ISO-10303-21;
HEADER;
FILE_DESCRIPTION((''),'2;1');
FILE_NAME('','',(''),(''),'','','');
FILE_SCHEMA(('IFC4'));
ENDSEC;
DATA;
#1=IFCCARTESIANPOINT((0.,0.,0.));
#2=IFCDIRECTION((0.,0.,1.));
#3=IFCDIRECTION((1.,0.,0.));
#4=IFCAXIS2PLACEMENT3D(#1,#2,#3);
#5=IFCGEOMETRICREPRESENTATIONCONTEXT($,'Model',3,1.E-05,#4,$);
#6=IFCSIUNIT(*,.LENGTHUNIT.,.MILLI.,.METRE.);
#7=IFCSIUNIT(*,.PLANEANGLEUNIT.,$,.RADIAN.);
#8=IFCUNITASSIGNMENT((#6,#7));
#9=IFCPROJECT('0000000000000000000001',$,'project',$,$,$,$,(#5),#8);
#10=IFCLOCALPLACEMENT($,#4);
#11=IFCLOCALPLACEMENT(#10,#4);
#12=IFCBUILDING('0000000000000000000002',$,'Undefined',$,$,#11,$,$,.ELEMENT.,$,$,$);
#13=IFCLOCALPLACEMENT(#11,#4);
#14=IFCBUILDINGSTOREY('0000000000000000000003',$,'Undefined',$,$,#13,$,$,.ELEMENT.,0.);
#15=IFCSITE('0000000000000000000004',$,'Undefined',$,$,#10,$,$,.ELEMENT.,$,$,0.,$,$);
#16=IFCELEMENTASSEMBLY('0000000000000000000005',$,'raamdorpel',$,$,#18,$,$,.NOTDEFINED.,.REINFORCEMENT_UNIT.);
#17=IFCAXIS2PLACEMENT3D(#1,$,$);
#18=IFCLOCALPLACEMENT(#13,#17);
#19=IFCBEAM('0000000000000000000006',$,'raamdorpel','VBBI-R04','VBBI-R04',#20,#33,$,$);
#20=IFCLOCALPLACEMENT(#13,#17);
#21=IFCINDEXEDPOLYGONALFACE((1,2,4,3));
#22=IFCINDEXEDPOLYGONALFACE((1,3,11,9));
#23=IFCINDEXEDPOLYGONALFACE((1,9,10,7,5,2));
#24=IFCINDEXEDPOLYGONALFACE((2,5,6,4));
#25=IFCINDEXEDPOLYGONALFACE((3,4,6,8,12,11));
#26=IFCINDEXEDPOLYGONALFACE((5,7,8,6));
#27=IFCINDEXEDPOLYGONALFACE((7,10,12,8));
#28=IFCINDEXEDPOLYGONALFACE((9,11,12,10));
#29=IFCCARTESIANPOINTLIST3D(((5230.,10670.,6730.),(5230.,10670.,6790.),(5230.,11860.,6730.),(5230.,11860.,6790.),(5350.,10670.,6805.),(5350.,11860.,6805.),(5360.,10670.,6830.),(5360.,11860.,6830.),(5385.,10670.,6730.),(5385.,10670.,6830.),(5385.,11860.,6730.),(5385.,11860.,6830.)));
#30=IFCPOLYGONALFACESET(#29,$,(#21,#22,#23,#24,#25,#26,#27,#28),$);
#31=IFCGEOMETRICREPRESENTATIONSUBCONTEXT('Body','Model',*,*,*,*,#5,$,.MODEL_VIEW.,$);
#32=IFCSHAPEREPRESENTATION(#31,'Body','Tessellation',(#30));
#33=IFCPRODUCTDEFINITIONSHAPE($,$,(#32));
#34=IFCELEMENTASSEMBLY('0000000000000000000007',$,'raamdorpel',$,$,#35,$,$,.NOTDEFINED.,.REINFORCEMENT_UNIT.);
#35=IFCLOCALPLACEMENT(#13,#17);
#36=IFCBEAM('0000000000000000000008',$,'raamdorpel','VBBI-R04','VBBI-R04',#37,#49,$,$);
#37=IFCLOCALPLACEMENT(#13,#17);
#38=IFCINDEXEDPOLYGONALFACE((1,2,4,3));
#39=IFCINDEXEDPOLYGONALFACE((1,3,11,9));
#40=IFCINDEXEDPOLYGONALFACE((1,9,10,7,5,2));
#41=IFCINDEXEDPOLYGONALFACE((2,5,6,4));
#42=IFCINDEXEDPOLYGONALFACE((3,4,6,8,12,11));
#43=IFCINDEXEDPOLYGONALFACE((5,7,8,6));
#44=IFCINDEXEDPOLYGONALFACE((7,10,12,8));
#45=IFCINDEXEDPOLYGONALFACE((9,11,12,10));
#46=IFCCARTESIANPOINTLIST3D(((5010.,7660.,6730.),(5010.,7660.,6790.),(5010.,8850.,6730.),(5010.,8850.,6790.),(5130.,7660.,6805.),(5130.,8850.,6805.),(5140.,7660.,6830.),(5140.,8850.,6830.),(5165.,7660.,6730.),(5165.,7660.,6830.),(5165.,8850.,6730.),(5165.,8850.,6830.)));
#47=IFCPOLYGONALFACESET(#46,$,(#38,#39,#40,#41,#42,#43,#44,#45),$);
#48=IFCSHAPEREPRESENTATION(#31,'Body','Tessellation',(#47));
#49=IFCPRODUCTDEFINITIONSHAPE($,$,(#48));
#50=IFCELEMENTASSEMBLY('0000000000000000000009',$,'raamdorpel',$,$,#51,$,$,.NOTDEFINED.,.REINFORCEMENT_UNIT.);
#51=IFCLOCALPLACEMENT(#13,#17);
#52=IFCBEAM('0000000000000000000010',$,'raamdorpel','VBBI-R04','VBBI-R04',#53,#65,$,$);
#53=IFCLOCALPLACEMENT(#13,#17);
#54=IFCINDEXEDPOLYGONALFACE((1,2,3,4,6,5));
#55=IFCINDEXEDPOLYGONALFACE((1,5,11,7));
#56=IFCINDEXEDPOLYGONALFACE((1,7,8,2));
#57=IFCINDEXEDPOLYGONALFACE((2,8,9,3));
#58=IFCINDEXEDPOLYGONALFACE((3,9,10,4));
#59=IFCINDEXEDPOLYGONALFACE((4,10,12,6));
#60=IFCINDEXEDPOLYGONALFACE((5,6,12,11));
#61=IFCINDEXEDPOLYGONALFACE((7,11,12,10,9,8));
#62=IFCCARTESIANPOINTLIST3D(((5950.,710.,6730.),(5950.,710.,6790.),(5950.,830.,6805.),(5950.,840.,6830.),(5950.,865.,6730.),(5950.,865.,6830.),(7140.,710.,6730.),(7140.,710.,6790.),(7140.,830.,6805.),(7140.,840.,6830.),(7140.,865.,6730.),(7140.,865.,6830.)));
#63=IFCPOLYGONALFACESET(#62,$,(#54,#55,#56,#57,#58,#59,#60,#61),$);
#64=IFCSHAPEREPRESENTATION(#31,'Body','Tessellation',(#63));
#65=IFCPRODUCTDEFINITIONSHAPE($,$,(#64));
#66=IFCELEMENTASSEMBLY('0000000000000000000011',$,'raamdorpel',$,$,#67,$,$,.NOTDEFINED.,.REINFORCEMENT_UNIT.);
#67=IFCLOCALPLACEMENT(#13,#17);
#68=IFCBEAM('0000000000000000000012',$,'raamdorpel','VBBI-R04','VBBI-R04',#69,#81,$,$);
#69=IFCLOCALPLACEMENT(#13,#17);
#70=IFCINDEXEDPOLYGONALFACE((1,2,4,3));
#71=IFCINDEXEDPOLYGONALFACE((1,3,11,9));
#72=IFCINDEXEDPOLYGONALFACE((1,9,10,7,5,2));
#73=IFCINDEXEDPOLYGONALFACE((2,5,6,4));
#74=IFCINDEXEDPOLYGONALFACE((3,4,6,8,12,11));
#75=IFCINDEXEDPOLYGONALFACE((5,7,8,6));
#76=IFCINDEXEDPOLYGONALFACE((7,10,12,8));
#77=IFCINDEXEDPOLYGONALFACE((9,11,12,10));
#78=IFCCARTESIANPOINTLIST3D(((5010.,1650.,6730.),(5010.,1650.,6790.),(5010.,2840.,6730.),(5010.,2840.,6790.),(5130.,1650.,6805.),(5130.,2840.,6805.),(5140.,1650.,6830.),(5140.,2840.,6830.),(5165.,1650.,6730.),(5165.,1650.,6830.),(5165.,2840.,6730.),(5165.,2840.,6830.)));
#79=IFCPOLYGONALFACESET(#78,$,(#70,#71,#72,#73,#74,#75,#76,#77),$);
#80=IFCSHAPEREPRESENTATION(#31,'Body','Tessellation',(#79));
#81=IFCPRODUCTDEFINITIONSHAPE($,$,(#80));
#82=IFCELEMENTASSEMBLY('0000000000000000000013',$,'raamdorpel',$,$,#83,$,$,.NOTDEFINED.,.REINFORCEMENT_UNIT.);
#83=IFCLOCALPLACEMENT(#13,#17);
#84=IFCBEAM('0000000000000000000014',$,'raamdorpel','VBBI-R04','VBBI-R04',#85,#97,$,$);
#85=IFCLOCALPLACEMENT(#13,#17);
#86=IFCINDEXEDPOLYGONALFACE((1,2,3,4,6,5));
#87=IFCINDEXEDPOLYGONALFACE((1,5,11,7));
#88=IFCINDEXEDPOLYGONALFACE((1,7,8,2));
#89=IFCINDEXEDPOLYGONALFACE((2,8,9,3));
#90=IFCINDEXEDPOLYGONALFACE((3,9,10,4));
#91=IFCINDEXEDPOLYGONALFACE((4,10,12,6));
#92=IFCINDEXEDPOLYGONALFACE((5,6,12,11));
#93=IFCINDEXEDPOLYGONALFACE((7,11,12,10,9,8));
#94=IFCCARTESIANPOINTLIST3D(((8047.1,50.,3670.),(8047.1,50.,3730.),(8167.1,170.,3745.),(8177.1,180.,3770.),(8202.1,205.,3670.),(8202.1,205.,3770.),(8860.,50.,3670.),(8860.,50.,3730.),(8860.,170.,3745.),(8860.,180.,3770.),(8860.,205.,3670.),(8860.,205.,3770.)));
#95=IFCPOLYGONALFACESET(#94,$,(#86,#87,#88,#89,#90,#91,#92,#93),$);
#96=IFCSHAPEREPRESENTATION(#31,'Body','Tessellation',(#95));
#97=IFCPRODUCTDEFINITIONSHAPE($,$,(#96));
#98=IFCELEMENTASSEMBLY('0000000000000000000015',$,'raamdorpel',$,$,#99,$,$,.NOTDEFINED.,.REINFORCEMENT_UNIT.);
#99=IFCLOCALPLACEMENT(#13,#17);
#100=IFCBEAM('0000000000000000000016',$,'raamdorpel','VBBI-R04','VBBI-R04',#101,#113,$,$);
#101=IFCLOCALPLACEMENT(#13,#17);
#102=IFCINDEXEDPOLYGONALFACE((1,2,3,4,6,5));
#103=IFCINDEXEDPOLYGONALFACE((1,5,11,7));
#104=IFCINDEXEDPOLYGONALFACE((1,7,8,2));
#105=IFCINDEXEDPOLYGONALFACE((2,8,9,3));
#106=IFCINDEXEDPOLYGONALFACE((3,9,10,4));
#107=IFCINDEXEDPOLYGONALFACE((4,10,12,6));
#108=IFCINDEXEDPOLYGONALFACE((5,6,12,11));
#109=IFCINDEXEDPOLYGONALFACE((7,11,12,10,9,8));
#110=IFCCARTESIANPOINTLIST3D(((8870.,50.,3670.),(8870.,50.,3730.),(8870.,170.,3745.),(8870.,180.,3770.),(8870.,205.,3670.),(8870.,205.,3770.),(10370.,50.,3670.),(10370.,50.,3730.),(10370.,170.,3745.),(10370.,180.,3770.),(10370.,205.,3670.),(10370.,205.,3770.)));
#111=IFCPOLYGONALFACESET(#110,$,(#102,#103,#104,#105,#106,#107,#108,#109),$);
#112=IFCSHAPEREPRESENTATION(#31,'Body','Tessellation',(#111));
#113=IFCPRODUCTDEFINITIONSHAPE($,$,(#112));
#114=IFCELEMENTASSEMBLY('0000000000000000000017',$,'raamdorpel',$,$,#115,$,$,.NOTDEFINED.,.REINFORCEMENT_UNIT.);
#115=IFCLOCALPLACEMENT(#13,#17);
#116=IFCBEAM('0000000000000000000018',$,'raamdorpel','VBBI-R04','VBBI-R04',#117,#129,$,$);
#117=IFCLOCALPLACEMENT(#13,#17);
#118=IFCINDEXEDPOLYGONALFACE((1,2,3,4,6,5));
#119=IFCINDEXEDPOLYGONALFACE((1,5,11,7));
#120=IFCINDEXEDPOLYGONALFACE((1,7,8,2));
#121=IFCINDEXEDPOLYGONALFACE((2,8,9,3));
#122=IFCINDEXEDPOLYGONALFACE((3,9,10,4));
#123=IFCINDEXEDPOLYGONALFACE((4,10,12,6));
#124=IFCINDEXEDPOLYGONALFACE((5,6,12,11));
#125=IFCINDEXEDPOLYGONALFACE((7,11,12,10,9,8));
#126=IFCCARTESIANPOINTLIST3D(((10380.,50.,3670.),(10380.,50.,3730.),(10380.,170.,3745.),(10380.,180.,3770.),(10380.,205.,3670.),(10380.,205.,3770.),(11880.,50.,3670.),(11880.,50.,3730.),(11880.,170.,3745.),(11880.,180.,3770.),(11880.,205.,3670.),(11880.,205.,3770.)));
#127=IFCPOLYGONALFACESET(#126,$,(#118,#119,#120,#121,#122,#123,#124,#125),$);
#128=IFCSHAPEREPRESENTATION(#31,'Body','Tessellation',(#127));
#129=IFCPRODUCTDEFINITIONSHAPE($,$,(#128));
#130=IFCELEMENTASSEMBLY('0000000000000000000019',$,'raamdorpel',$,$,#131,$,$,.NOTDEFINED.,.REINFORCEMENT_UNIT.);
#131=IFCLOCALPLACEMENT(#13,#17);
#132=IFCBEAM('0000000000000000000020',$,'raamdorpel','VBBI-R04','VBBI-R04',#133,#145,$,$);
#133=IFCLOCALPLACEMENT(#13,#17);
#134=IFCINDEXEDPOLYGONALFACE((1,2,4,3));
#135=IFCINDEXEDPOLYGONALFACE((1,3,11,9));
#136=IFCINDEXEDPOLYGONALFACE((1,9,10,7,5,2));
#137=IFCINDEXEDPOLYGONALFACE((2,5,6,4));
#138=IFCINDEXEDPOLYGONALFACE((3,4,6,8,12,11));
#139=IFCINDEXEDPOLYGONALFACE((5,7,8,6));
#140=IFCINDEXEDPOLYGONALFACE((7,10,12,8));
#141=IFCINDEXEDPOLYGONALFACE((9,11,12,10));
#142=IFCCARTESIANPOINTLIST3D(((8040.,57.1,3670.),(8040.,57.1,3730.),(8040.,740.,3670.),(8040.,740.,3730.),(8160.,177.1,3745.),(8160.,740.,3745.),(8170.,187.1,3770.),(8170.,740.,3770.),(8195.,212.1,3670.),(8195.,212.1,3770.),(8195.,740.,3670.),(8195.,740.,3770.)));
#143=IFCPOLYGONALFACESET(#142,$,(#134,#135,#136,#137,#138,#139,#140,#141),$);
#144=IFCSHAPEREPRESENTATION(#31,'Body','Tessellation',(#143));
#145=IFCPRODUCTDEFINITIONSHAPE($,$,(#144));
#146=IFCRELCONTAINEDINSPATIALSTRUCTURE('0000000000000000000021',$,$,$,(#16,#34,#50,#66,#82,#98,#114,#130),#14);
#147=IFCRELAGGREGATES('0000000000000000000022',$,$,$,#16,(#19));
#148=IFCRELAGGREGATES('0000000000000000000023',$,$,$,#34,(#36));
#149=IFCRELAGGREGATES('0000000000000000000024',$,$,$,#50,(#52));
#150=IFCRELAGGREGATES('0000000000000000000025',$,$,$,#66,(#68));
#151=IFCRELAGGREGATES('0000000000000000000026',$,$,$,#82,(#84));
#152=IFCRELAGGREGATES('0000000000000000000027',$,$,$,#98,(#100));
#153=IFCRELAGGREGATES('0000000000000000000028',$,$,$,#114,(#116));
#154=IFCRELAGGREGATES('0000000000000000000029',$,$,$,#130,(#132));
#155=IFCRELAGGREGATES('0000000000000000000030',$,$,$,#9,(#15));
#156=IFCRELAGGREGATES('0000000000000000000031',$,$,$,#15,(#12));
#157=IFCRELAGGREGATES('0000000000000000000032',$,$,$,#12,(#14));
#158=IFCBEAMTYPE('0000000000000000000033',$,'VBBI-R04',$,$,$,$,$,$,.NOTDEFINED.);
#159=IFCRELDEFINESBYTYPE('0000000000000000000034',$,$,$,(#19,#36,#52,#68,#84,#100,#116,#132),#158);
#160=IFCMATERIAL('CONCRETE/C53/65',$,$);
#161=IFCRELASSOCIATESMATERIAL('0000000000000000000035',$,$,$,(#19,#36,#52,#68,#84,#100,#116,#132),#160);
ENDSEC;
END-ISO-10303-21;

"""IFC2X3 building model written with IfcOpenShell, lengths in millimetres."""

from ifc_helpers import new_model, si_unit, frame, origin_with_axes, place, context, subcontext, project, spatial, polyline, outline, extrude, clip, halfspace, material, type_object, element, aggregate, save


model = new_model("IFC2X3")

# Units and contexts
model_context = context("Model", 3, precision=1e-05, world=origin_with_axes())
body_context = subcontext(model_context, "Body", "Model", "MODEL_VIEW")
ifc_project = project(units=[si_unit("LENGTHUNIT", "METRE", prefix="MILLI"), si_unit("PLANEANGLEUNIT", "RADIAN")], contexts=[model_context])

# Site, building, storey
site_placement = place(None, origin_with_axes())
site = spatial("IfcSite", under=ifc_project, at=site_placement, Name="Undefined", CompositionType="ELEMENT", RefElevation=0.0)
building_placement = place(site_placement, origin_with_axes())
building = spatial("IfcBuilding", under=site, at=building_placement, Name="Undefined", CompositionType="ELEMENT")
storey_placement = place(building_placement, origin_with_axes())
storey = spatial("IfcBuildingStorey", under=building, at=storey_placement, Name="Undefined", CompositionType="ELEMENT", Elevation=0.0)

# Element assemblies, beams
ifc_material = material(Name="CONCRETE/C53/65")
assembly_1_placement = place(storey_placement, origin_with_axes())
assembly_1 = element("IfcElementAssembly", 1, at=assembly_1_placement, inside=storey, Name="raamdorpel", AssemblyPlace="NOTDEFINED", PredefinedType="REINFORCEMENT_UNIT")
beam_type_1 = type_object("IfcBeamType", Name="VBBI-R04", PredefinedType="NOTDEFINED")
beam_1_placement = place(assembly_1_placement, frame((5307.5, 11860.0, 6780.0), z_axis=(-1.0, 0.0, 0.0), x_axis=(0.0, -1.0, 0.0)))
beam_1 = element("IfcBeam", 2, at=beam_1_placement, type_object=beam_type_1, material=ifc_material, Name="raamdorpel", Description="VBBI-R04", ObjectType="VBBI-R04", context=body_context, shape_type="SweptSolid", body=[
    extrude(outline(polyline([(50.0, -77.5), (-50.0, -77.5), (-50.0, -52.5), (-25.0, -42.5), (-10.0, 77.5), (50.0, 77.5), (50.0, -77.5)])), frame((1190.0, 0.0, 0.0), z_axis=(-1.0, 0.0, 0.0), x_axis=(0.0, -1.0, 0.0)), (0.0, 0.0, 1.0), 1190.0),
])
aggregate(assembly_1, [beam_1])
assembly_2_placement = place(storey_placement, origin_with_axes())
assembly_2 = element("IfcElementAssembly", 3, at=assembly_2_placement, inside=storey, Name="raamdorpel", AssemblyPlace="NOTDEFINED", PredefinedType="REINFORCEMENT_UNIT")
beam_2_placement = place(assembly_2_placement, frame((5087.5, 8850.0, 6780.0), z_axis=(-1.0, 0.0, 0.0), x_axis=(0.0, -1.0, 0.0)))
beam_2 = element("IfcBeam", 4, at=beam_2_placement, type_object=beam_type_1, material=ifc_material, Name="raamdorpel", Description="VBBI-R04", ObjectType="VBBI-R04", context=body_context, shape_type="SweptSolid", body=[
    extrude(outline(polyline([(50.0, -77.5), (-50.0, -77.5), (-50.0, -52.5), (-25.0, -42.5), (-10.0, 77.5), (50.0, 77.5), (50.0, -77.5)])), frame((1190.0, 0.0, 0.0), z_axis=(-1.0, 0.0, 0.0), x_axis=(0.0, -1.0, 0.0)), (0.0, 0.0, 1.0), 1190.0),
])
aggregate(assembly_2, [beam_2])
assembly_3_placement = place(storey_placement, origin_with_axes())
assembly_3 = element("IfcElementAssembly", 5, at=assembly_3_placement, inside=storey, Name="raamdorpel", AssemblyPlace="NOTDEFINED", PredefinedType="REINFORCEMENT_UNIT")
beam_3_placement = place(assembly_3_placement, frame((5950.0, 787.5, 6780.0), z_axis=(0.0, -1.0, 0.0), x_axis=(1.0, 0.0, 0.0)))
beam_3 = element("IfcBeam", 6, at=beam_3_placement, type_object=beam_type_1, material=ifc_material, Name="raamdorpel", Description="VBBI-R04", ObjectType="VBBI-R04", context=body_context, shape_type="SweptSolid", body=[
    extrude(outline(polyline([(50.0, -77.5), (-50.0, -77.5), (-50.0, -52.5), (-25.0, -42.5), (-10.0, 77.5), (50.0, 77.5), (50.0, -77.5)])), frame((1190.0, 0.0, 0.0), z_axis=(-1.0, 0.0, 0.0), x_axis=(0.0, -1.0, 0.0)), (0.0, 0.0, 1.0), 1190.0),
])
aggregate(assembly_3, [beam_3])
assembly_4_placement = place(storey_placement, origin_with_axes())
assembly_4 = element("IfcElementAssembly", 7, at=assembly_4_placement, inside=storey, Name="raamdorpel", AssemblyPlace="NOTDEFINED", PredefinedType="REINFORCEMENT_UNIT")
beam_4_placement = place(assembly_4_placement, frame((5087.5, 2840.0, 6780.0), z_axis=(-1.0, 0.0, 0.0), x_axis=(0.0, -1.0, 0.0)))
beam_4 = element("IfcBeam", 8, at=beam_4_placement, type_object=beam_type_1, material=ifc_material, Name="raamdorpel", Description="VBBI-R04", ObjectType="VBBI-R04", context=body_context, shape_type="SweptSolid", body=[
    extrude(outline(polyline([(50.0, -77.5), (-50.0, -77.5), (-50.0, -52.5), (-25.0, -42.5), (-10.0, 77.5), (50.0, 77.5), (50.0, -77.5)])), frame((1190.0, 0.0, 0.0), z_axis=(-1.0, 0.0, 0.0), x_axis=(0.0, -1.0, 0.0)), (0.0, 0.0, 1.0), 1190.0),
])
aggregate(assembly_4, [beam_4])
assembly_5_placement = place(storey_placement, origin_with_axes())
assembly_5 = element("IfcElementAssembly", 9, at=assembly_5_placement, inside=storey, Name="raamdorpel", AssemblyPlace="NOTDEFINED", PredefinedType="REINFORCEMENT_UNIT")
beam_5_placement = place(assembly_5_placement, frame((8040.0, 127.5, 3720.0), z_axis=(0.0, -1.0, 0.0), x_axis=(1.0, 0.0, 0.0)))
beam_5 = element("IfcBeam", 10, at=beam_5_placement, type_object=beam_type_1, material=ifc_material, Name="raamdorpel", Description="VBBI-R04", ObjectType="VBBI-R04", context=body_context, shape_type="Clipping", body=[
    clip(extrude(outline(polyline([(50.0, -77.5), (-50.0, -77.5), (-50.0, -52.5), (-25.0, -42.5), (-10.0, 77.5), (50.0, 77.5), (50.0, -77.5)])), frame((820.0, 0.0, 0.0), z_axis=(-1.0, 0.0, 0.0), x_axis=(0.0, -1.0, 0.0)), (0.0, 0.0, 1.0), 813.7), halfspace(frame((3.5, 0.0, 81.0), z_axis=(0.707107, 0.0, 0.707106), x_axis=(0.0, 1.0, 0.0)), True)),
])
aggregate(assembly_5, [beam_5])
assembly_6_placement = place(storey_placement, origin_with_axes())
assembly_6 = element("IfcElementAssembly", 11, at=assembly_6_placement, inside=storey, Name="raamdorpel", AssemblyPlace="NOTDEFINED", PredefinedType="REINFORCEMENT_UNIT")
beam_6_placement = place(assembly_6_placement, frame((8870.0, 127.5, 3720.0), z_axis=(0.0, -1.0, 0.0), x_axis=(1.0, 0.0, 0.0)))
beam_6 = element("IfcBeam", 12, at=beam_6_placement, type_object=beam_type_1, material=ifc_material, Name="raamdorpel", Description="VBBI-R04", ObjectType="VBBI-R04", context=body_context, shape_type="SweptSolid", body=[
    extrude(outline(polyline([(50.0, -77.5), (-50.0, -77.5), (-50.0, -52.5), (-25.0, -42.5), (-10.0, 77.5), (50.0, 77.5), (50.0, -77.5)])), frame((1500.0, 0.0, 0.0), z_axis=(-1.0, 0.0, 0.0), x_axis=(0.0, -1.0, 0.0)), (0.0, 0.0, 1.0), 1500.0),
])
aggregate(assembly_6, [beam_6])
assembly_7_placement = place(storey_placement, origin_with_axes())
assembly_7 = element("IfcElementAssembly", 13, at=assembly_7_placement, inside=storey, Name="raamdorpel", AssemblyPlace="NOTDEFINED", PredefinedType="REINFORCEMENT_UNIT")
beam_7_placement = place(assembly_7_placement, frame((10380.0, 127.5, 3720.0), z_axis=(0.0, -1.0, 0.0), x_axis=(1.0, 0.0, 0.0)))
beam_7 = element("IfcBeam", 14, at=beam_7_placement, type_object=beam_type_1, material=ifc_material, Name="raamdorpel", Description="VBBI-R04", ObjectType="VBBI-R04", context=body_context, shape_type="SweptSolid", body=[
    extrude(outline(polyline([(50.0, -77.5), (-50.0, -77.5), (-50.0, -52.5), (-25.0, -42.5), (-10.0, 77.5), (50.0, 77.5), (50.0, -77.5)])), frame((1500.0, 0.0, 0.0), z_axis=(-1.0, 0.0, 0.0), x_axis=(0.0, -1.0, 0.0)), (0.0, 0.0, 1.0), 1500.0),
])
aggregate(assembly_7, [beam_7])
assembly_8_placement = place(storey_placement, origin_with_axes())
assembly_8 = element("IfcElementAssembly", 15, at=assembly_8_placement, inside=storey, Name="raamdorpel", AssemblyPlace="NOTDEFINED", PredefinedType="REINFORCEMENT_UNIT")
beam_8_placement = place(assembly_8_placement, frame((8117.5, 740.0, 3720.0), z_axis=(-1.0, -0.000003, 0.0), x_axis=(0.000003, -1.0, 0.0)))
beam_8 = element("IfcBeam", 16, at=beam_8_placement, type_object=beam_type_1, material=ifc_material, Name="raamdorpel", Description="VBBI-R04", ObjectType="VBBI-R04", context=body_context, shape_type="Clipping", body=[
    clip(extrude(outline(polyline([(50.0, -77.5), (-50.0, -77.5), (-50.0, -52.5), (-25.0, -42.5), (-10.0, 77.5), (50.0, 77.5), (50.0, -77.5)])), frame((683.7, 0.0, 0.0), z_axis=(-1.0, 0.0, 0.0), x_axis=(0.0, -1.0, 0.0)), (0.0, 0.0, 1.0), 683.7), halfspace(frame((686.5, 0.0, 81.0), z_axis=(0.707108, 0.0, -0.707106), x_axis=(0.0, 1.0, 0.0)), False)),
])
aggregate(assembly_8, [beam_8])

save(model, "model.ifc")
